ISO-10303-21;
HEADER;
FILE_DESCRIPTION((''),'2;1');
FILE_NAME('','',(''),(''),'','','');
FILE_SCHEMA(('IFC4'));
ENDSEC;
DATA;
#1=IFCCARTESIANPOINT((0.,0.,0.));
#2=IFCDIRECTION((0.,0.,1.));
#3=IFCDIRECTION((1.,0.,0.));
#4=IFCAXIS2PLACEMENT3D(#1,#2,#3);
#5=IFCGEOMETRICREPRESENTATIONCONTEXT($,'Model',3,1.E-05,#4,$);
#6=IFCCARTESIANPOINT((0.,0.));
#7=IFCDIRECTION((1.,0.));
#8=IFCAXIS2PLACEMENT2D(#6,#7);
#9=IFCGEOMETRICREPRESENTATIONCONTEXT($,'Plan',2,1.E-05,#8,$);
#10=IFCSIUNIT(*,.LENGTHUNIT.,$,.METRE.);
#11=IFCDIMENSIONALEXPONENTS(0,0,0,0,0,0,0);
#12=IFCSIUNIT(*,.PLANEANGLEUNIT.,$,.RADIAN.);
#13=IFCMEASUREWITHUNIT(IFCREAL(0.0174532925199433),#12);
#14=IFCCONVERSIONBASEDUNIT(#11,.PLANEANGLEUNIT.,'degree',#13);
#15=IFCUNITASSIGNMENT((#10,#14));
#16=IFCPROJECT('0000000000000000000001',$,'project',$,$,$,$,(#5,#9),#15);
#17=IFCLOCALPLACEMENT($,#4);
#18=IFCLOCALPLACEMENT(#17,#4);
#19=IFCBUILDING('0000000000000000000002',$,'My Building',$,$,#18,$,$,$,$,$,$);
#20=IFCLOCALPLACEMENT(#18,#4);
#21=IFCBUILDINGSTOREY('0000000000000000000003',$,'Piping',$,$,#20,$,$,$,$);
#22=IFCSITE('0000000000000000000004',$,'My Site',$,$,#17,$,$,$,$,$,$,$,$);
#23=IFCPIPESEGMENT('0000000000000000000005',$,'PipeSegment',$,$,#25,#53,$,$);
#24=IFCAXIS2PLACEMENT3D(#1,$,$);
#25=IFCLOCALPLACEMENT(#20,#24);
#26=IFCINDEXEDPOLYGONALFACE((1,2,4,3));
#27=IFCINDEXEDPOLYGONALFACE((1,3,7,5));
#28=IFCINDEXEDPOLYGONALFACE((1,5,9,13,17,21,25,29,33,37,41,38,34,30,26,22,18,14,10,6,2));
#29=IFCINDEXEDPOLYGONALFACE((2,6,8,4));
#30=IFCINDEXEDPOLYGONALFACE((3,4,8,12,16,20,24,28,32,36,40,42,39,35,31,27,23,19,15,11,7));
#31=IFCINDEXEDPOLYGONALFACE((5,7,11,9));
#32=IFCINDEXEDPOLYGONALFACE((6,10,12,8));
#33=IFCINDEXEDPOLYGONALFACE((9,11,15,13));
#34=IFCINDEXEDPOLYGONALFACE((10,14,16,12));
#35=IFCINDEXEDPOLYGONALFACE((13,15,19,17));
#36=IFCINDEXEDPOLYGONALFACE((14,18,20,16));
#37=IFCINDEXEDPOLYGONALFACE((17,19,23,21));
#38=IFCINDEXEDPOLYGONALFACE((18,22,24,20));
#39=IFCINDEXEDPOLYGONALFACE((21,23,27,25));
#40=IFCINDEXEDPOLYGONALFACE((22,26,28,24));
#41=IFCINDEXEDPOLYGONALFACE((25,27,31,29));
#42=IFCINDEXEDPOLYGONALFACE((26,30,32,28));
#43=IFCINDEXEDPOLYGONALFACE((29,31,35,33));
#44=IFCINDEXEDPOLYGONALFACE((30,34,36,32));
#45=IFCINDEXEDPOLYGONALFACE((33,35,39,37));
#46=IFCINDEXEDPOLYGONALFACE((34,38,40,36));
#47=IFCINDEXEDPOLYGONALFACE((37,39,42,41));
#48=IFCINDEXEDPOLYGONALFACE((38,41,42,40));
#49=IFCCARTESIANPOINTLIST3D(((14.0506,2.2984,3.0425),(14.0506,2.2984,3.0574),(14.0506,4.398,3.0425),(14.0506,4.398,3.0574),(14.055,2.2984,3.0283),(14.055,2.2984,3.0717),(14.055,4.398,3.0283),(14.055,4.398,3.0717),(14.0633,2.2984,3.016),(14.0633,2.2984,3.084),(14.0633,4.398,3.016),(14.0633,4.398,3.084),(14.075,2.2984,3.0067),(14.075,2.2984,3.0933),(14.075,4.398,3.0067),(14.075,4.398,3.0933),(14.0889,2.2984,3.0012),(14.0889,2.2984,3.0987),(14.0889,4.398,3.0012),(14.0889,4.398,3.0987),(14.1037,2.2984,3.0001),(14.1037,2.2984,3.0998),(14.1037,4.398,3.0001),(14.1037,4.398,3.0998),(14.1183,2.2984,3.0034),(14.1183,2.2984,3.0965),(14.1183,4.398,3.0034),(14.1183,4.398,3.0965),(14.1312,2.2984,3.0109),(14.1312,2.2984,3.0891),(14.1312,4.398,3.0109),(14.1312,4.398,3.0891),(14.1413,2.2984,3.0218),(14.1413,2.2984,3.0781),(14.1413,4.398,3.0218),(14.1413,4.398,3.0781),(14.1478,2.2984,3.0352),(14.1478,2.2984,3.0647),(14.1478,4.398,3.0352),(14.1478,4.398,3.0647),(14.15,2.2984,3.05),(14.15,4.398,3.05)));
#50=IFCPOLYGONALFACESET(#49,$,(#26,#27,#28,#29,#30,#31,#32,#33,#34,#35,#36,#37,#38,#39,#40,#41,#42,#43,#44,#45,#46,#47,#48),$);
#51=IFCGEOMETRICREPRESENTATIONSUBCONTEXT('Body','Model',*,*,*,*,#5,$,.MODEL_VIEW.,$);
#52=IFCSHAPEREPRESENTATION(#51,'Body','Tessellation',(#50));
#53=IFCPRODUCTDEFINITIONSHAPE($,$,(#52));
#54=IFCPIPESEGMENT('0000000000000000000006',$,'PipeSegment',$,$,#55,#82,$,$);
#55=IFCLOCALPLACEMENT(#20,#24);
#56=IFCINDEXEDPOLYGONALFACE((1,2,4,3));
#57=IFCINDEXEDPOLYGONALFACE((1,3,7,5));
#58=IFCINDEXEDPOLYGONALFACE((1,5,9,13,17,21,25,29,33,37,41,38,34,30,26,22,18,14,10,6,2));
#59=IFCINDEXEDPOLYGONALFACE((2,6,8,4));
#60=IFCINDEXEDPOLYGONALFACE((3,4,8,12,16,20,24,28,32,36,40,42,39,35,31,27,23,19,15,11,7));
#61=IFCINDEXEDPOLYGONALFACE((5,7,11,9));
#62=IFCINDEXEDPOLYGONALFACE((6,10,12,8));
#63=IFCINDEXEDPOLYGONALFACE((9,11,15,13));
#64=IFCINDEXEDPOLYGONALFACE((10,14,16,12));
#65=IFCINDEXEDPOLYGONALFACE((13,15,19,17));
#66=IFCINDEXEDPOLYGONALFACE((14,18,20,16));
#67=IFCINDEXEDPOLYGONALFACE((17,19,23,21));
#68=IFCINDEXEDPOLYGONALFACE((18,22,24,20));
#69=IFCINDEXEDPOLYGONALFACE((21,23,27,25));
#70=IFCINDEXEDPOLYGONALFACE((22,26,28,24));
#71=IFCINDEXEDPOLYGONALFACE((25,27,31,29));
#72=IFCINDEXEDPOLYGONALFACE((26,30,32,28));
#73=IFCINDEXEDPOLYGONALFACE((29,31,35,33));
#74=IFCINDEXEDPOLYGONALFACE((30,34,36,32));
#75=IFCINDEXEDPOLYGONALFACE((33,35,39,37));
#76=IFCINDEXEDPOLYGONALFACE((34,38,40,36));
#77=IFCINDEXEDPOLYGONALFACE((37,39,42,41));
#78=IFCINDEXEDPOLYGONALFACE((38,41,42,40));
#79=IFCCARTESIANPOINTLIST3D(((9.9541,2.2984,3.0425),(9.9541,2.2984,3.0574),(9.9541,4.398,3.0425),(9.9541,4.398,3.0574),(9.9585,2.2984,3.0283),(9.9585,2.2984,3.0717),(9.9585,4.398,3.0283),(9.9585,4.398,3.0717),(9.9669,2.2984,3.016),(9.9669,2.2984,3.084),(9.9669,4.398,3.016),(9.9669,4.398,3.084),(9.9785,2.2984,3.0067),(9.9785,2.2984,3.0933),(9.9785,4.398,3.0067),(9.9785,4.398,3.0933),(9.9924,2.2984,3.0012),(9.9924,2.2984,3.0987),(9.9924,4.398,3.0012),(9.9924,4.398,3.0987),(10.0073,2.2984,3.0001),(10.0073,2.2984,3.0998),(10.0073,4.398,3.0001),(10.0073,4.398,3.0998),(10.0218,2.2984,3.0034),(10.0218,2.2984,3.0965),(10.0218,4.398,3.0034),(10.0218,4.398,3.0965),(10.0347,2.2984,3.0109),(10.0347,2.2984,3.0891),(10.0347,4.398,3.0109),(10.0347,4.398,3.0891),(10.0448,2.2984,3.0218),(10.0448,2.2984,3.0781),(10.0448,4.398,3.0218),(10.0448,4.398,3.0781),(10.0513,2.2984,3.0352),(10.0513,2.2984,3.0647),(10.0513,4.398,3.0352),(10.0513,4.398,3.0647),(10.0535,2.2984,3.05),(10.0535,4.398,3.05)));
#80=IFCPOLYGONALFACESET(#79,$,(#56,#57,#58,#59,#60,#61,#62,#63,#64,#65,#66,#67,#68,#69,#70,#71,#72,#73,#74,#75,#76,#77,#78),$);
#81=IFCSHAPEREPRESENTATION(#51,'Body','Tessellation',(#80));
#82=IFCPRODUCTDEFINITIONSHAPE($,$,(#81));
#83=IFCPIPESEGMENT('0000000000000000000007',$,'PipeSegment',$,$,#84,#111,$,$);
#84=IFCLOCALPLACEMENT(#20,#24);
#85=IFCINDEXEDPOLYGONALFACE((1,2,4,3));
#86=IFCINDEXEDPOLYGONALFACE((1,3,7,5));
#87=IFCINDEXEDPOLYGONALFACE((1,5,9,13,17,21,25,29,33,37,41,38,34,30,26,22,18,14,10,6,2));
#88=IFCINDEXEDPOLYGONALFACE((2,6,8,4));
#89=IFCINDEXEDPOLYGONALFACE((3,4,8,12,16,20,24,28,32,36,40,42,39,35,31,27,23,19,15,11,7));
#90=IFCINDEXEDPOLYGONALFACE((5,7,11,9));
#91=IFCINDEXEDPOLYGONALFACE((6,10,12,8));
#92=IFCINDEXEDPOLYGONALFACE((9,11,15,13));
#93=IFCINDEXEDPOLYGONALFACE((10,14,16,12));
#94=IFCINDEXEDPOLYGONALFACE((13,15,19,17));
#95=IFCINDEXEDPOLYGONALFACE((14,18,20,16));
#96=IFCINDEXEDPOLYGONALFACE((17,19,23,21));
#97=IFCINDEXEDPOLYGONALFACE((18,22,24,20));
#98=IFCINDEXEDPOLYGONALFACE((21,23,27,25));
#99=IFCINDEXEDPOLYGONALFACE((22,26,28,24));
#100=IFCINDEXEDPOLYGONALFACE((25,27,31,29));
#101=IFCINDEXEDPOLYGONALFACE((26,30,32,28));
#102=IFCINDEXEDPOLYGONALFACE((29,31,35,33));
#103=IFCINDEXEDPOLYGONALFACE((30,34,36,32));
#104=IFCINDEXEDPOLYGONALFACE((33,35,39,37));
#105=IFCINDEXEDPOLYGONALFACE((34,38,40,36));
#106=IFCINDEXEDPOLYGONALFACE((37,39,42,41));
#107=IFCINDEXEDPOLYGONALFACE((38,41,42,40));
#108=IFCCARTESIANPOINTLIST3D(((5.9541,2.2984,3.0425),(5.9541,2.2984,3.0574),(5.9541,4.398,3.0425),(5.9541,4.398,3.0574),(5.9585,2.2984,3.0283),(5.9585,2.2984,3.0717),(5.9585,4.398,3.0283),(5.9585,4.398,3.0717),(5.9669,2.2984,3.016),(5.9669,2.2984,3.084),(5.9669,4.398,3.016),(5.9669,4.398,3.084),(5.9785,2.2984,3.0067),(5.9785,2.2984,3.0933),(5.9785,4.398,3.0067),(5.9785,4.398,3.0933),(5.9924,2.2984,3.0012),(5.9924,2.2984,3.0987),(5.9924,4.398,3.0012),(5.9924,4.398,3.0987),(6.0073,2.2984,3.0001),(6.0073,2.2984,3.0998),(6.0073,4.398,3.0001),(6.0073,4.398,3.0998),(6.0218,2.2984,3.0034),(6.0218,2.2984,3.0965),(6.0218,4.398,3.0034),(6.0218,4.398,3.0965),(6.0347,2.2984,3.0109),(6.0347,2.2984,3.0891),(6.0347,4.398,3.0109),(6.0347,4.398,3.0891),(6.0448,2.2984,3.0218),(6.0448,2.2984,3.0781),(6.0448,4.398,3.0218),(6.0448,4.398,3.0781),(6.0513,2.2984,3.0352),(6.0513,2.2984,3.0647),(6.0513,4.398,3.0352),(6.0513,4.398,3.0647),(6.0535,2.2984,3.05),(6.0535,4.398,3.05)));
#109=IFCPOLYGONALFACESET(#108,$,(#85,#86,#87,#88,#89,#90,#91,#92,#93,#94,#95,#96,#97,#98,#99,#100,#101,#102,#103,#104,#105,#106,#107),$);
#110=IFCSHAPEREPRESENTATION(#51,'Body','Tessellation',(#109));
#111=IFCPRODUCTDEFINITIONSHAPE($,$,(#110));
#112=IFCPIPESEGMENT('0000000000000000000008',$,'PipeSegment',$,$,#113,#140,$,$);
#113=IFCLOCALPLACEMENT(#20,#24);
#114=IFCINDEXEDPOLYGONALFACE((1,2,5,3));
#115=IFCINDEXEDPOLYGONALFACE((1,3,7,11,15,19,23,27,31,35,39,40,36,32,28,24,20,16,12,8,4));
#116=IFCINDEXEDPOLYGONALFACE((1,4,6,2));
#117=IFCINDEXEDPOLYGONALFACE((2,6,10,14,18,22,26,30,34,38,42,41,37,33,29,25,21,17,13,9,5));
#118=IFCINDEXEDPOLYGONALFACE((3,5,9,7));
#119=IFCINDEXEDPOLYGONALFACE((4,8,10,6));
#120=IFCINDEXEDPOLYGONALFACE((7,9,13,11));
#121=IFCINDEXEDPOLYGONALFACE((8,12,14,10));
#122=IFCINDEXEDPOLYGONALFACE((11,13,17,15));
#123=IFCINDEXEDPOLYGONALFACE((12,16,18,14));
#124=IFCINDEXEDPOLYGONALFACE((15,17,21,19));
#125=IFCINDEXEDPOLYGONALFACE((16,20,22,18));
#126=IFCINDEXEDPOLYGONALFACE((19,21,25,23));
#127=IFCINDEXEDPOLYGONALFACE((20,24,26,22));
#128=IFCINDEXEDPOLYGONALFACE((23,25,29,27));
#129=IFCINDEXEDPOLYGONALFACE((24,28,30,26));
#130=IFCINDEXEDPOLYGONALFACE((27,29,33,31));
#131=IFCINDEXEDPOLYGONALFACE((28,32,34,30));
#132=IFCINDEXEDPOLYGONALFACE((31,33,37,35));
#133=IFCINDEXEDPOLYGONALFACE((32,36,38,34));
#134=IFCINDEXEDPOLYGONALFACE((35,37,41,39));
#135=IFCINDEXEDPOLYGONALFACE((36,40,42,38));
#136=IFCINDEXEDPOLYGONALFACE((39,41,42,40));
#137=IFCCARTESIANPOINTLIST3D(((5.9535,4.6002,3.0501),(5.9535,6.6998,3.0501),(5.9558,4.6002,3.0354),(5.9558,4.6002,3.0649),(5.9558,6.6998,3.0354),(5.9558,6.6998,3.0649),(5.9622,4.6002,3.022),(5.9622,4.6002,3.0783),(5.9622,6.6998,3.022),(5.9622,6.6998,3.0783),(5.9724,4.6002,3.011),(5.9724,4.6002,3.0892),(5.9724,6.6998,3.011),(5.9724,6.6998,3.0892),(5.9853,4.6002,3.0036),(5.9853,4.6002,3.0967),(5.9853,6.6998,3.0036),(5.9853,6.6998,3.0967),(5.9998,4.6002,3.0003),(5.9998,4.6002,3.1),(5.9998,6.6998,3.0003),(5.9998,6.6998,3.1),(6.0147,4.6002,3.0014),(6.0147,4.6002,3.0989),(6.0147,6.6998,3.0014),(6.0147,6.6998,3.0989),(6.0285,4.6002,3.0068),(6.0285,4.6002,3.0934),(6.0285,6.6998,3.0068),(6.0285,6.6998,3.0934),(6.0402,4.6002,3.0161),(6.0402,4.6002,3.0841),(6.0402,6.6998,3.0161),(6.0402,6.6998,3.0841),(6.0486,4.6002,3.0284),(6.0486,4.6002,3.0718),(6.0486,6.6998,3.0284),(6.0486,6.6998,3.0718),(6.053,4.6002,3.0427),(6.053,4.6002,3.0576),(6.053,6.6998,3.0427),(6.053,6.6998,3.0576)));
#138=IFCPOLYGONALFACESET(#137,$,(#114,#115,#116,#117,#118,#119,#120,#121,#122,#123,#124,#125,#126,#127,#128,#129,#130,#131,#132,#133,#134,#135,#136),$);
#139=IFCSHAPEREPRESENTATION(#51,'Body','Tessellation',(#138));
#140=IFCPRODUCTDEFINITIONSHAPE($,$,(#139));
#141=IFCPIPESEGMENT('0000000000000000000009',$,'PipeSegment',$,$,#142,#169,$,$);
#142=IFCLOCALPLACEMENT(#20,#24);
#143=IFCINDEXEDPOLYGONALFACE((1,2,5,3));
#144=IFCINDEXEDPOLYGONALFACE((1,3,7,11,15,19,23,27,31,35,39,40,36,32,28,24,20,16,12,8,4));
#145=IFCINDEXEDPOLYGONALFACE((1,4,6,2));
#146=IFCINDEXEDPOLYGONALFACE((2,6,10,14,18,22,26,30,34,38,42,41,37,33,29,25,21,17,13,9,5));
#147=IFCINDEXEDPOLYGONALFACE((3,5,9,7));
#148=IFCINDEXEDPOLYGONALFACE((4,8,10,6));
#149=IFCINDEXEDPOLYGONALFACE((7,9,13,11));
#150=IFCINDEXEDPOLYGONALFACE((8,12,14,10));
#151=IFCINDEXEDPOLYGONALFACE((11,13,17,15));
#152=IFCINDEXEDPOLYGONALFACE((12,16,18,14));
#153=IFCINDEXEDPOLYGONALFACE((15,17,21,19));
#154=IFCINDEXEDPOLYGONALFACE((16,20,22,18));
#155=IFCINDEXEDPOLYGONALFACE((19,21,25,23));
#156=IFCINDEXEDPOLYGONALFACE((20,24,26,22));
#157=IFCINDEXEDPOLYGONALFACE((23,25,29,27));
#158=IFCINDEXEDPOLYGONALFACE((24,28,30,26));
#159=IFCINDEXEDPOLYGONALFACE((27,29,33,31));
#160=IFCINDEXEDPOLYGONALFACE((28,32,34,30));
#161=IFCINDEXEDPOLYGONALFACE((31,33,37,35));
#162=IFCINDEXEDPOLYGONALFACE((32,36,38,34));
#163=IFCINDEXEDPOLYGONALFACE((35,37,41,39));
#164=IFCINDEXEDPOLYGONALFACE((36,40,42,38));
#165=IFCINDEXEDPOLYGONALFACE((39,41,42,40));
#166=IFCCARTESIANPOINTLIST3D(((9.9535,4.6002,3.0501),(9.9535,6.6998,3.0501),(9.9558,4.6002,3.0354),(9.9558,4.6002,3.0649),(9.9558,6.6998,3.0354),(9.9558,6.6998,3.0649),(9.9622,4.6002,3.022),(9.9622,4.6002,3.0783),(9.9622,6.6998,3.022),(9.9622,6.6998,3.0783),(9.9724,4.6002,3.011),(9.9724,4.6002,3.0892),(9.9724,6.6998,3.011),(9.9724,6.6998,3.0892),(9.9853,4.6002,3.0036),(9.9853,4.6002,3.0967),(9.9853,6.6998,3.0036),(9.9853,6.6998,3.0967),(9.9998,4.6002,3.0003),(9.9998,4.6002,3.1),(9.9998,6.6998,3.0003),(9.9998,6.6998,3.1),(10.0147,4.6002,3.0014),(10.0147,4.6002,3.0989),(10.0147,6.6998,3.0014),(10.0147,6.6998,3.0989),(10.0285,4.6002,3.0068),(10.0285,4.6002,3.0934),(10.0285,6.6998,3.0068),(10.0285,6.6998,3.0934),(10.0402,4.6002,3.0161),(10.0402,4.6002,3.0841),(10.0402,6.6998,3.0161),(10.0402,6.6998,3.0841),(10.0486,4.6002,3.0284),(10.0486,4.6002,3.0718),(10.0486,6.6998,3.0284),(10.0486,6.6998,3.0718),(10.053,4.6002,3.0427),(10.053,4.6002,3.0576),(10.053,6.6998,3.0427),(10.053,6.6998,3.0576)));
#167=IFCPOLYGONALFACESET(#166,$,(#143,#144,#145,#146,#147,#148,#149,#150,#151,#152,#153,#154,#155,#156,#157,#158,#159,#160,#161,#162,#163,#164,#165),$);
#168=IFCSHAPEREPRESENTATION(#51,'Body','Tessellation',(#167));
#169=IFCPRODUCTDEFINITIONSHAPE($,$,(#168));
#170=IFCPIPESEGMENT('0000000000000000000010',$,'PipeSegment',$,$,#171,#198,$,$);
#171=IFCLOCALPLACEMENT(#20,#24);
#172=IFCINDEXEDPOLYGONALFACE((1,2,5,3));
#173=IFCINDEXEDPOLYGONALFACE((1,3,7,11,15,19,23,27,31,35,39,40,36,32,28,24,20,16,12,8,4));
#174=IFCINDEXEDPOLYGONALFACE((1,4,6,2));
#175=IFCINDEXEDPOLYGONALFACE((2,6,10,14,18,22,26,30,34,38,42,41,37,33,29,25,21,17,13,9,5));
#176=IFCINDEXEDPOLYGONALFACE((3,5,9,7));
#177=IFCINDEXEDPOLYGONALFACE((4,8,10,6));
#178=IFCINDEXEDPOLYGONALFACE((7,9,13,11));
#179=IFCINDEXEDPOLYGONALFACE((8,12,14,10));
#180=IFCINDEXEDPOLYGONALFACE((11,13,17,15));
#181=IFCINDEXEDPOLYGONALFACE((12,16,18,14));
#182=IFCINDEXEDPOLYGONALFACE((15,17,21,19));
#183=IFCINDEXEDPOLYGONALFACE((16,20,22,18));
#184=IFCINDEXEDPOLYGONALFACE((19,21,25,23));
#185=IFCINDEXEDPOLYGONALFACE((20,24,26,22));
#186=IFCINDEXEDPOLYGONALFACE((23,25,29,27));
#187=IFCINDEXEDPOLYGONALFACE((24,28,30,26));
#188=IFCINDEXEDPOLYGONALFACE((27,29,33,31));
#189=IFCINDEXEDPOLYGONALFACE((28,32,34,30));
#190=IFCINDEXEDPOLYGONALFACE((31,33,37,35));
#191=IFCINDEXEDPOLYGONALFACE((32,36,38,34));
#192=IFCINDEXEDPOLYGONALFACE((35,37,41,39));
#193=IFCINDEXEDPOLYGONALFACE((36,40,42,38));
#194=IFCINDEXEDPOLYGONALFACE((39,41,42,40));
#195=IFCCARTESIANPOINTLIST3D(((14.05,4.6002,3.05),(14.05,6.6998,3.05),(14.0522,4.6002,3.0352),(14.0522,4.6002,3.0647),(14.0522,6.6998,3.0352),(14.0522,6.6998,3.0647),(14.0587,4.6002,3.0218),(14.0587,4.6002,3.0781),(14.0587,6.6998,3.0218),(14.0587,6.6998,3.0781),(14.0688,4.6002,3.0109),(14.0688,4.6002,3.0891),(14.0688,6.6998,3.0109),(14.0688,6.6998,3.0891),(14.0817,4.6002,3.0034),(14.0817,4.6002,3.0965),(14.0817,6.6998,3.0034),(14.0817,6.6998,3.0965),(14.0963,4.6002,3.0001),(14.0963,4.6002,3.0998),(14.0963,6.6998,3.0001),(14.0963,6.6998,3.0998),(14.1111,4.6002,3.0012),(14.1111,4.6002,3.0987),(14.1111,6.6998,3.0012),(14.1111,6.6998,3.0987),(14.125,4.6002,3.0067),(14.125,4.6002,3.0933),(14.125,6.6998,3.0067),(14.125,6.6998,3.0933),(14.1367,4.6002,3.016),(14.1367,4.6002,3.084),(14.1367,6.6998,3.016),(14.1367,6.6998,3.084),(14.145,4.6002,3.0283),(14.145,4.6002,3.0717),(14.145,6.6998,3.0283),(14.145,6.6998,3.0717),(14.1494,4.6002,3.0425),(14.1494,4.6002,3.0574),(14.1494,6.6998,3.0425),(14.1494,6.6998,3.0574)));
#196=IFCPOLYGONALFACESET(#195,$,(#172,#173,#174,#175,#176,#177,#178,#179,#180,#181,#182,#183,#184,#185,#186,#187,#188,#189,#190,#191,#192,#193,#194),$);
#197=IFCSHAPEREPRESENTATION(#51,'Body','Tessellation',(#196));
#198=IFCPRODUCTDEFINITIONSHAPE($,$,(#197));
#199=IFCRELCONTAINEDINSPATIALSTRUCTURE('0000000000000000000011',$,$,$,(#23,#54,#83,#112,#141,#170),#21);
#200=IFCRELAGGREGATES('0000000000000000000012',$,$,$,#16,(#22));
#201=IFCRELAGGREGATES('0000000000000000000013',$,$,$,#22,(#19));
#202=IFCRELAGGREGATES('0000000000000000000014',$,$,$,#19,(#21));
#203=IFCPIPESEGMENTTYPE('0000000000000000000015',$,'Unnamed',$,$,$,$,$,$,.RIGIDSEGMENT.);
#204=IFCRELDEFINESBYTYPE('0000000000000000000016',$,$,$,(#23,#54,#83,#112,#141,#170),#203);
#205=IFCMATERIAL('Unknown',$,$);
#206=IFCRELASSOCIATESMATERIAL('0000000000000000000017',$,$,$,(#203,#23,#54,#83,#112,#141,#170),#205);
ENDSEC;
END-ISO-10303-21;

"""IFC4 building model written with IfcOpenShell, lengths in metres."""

from ifc_helpers import new_model, entity, si_unit, converted_unit, frame, origin_with_axes, origin_2d_with_axis, place, context, subcontext, project, spatial, circle, extrude, material, material_profile, profile_set, profile_usage, type_object, element, save


model = new_model("IFC4")

# Units and contexts
model_context = context("Model", 3, precision=1e-05, world=origin_with_axes())
plan_context = context("Plan", 2, precision=1e-05, world=origin_2d_with_axis())
body_context = subcontext(model_context, "Body", "Model", "MODEL_VIEW")
ifc_project = project(units=[si_unit("LENGTHUNIT", "METRE"), converted_unit("PLANEANGLEUNIT", "degree", entity("IfcReal", 0.0174532925199433), si_unit("PLANEANGLEUNIT", "RADIAN"), dimensions=[0, 0, 0, 0, 0, 0, 0])], contexts=[model_context, plan_context])

# Site, building, storey
site_placement = place(None, origin_with_axes())
site = spatial("IfcSite", under=ifc_project, at=site_placement, Name="My Site")
building_placement = place(site_placement, origin_with_axes())
building = spatial("IfcBuilding", under=site, at=building_placement, Name="My Building")
storey_placement = place(building_placement, origin_with_axes())
storey = spatial("IfcBuildingStorey", under=building, at=storey_placement, Name="Piping")

# Pipe segments
ifc_material = material(Name="Unknown")
ifc_material_profile_1 = material_profile(ifc_material, circle(Radius=0.05))
ifc_profile_set_1 = profile_set([ifc_material_profile_1])
pipe_segment_type = type_object("IfcPipeSegmentType", Name="Unnamed", PredefinedType="RIGIDSEGMENT", material=ifc_profile_set_1)
ifc_profile_usage_1 = profile_usage(ifc_profile_set_1, cardinal=5)
pipe_segment_1_placement = place(storey_placement, frame((14.1, 2.2984, 3.05), z_axis=(0.0, 1.0, -0.000001), x_axis=(1.0, 0.0, 0.000001)))
element("IfcPipeSegment", 1, at=pipe_segment_1_placement, inside=storey, type_object=pipe_segment_type, material=ifc_profile_usage_1, Name="PipeSegment", context=body_context, shape_type="SweptSolid", body=[
    extrude(circle(Radius=0.05), origin_with_axes(), (0.0, 0.0, 1.0), 2.0996),
])
ifc_profile_usage_2 = profile_usage(ifc_profile_set_1, cardinal=5)
pipe_segment_2_placement = place(storey_placement, frame((10.0035, 2.2984, 3.05), z_axis=(0.0, 1.0, -0.000001), x_axis=(1.0, 0.0, 0.000001)))
element("IfcPipeSegment", 2, at=pipe_segment_2_placement, inside=storey, type_object=pipe_segment_type, material=ifc_profile_usage_2, Name="PipeSegment", context=body_context, shape_type="SweptSolid", body=[
    extrude(circle(Radius=0.05), origin_with_axes(), (0.0, 0.0, 1.0), 2.0996),
])
ifc_profile_usage_3 = profile_usage(ifc_profile_set_1, cardinal=5)
pipe_segment_3_placement = place(storey_placement, frame((6.0035, 2.2984, 3.05), z_axis=(0.0, 1.0, -0.000001), x_axis=(1.0, 0.0, 0.000001)))
element("IfcPipeSegment", 3, at=pipe_segment_3_placement, inside=storey, type_object=pipe_segment_type, material=ifc_profile_usage_3, Name="PipeSegment", context=body_context, shape_type="SweptSolid", body=[
    extrude(circle(Radius=0.05), origin_with_axes(), (0.0, 0.0, 1.0), 2.0996),
])
ifc_profile_usage_4 = profile_usage(ifc_profile_set_1, cardinal=5)
pipe_segment_4_placement = place(storey_placement, frame((6.0035, 6.6998, 3.0501), z_axis=(0.0, -1.0, -0.000001), x_axis=(-1.0, 0.0, 0.000001)))
element("IfcPipeSegment", 4, at=pipe_segment_4_placement, inside=storey, type_object=pipe_segment_type, material=ifc_profile_usage_4, Name="PipeSegment", context=body_context, shape_type="SweptSolid", body=[
    extrude(circle(Radius=0.05), origin_with_axes(), (0.0, 0.0, 1.0), 2.0996),
])
ifc_profile_usage_5 = profile_usage(ifc_profile_set_1, cardinal=5)
pipe_segment_5_placement = place(storey_placement, frame((10.0035, 6.6998, 3.0501), z_axis=(0.0, -1.0, -0.000001), x_axis=(-1.0, 0.0, 0.000001)))
element("IfcPipeSegment", 5, at=pipe_segment_5_placement, inside=storey, type_object=pipe_segment_type, material=ifc_profile_usage_5, Name="PipeSegment", context=body_context, shape_type="SweptSolid", body=[
    extrude(circle(Radius=0.05), origin_with_axes(), (0.0, 0.0, 1.0), 2.0996),
])
ifc_profile_usage_6 = profile_usage(ifc_profile_set_1, cardinal=5)
pipe_segment_6_placement = place(storey_placement, frame((14.1, 6.6998, 3.05), z_axis=(0.0, -1.0, 0.0), x_axis=(-1.0, 0.0, 0.000001)))
element("IfcPipeSegment", 6, at=pipe_segment_6_placement, inside=storey, type_object=pipe_segment_type, material=ifc_profile_usage_6, Name="PipeSegment", context=body_context, shape_type="SweptSolid", body=[
    extrude(circle(Radius=0.05), origin_with_axes(), (0.0, 0.0, 1.0), 2.0996),
])

save(model, "model.ifc")
